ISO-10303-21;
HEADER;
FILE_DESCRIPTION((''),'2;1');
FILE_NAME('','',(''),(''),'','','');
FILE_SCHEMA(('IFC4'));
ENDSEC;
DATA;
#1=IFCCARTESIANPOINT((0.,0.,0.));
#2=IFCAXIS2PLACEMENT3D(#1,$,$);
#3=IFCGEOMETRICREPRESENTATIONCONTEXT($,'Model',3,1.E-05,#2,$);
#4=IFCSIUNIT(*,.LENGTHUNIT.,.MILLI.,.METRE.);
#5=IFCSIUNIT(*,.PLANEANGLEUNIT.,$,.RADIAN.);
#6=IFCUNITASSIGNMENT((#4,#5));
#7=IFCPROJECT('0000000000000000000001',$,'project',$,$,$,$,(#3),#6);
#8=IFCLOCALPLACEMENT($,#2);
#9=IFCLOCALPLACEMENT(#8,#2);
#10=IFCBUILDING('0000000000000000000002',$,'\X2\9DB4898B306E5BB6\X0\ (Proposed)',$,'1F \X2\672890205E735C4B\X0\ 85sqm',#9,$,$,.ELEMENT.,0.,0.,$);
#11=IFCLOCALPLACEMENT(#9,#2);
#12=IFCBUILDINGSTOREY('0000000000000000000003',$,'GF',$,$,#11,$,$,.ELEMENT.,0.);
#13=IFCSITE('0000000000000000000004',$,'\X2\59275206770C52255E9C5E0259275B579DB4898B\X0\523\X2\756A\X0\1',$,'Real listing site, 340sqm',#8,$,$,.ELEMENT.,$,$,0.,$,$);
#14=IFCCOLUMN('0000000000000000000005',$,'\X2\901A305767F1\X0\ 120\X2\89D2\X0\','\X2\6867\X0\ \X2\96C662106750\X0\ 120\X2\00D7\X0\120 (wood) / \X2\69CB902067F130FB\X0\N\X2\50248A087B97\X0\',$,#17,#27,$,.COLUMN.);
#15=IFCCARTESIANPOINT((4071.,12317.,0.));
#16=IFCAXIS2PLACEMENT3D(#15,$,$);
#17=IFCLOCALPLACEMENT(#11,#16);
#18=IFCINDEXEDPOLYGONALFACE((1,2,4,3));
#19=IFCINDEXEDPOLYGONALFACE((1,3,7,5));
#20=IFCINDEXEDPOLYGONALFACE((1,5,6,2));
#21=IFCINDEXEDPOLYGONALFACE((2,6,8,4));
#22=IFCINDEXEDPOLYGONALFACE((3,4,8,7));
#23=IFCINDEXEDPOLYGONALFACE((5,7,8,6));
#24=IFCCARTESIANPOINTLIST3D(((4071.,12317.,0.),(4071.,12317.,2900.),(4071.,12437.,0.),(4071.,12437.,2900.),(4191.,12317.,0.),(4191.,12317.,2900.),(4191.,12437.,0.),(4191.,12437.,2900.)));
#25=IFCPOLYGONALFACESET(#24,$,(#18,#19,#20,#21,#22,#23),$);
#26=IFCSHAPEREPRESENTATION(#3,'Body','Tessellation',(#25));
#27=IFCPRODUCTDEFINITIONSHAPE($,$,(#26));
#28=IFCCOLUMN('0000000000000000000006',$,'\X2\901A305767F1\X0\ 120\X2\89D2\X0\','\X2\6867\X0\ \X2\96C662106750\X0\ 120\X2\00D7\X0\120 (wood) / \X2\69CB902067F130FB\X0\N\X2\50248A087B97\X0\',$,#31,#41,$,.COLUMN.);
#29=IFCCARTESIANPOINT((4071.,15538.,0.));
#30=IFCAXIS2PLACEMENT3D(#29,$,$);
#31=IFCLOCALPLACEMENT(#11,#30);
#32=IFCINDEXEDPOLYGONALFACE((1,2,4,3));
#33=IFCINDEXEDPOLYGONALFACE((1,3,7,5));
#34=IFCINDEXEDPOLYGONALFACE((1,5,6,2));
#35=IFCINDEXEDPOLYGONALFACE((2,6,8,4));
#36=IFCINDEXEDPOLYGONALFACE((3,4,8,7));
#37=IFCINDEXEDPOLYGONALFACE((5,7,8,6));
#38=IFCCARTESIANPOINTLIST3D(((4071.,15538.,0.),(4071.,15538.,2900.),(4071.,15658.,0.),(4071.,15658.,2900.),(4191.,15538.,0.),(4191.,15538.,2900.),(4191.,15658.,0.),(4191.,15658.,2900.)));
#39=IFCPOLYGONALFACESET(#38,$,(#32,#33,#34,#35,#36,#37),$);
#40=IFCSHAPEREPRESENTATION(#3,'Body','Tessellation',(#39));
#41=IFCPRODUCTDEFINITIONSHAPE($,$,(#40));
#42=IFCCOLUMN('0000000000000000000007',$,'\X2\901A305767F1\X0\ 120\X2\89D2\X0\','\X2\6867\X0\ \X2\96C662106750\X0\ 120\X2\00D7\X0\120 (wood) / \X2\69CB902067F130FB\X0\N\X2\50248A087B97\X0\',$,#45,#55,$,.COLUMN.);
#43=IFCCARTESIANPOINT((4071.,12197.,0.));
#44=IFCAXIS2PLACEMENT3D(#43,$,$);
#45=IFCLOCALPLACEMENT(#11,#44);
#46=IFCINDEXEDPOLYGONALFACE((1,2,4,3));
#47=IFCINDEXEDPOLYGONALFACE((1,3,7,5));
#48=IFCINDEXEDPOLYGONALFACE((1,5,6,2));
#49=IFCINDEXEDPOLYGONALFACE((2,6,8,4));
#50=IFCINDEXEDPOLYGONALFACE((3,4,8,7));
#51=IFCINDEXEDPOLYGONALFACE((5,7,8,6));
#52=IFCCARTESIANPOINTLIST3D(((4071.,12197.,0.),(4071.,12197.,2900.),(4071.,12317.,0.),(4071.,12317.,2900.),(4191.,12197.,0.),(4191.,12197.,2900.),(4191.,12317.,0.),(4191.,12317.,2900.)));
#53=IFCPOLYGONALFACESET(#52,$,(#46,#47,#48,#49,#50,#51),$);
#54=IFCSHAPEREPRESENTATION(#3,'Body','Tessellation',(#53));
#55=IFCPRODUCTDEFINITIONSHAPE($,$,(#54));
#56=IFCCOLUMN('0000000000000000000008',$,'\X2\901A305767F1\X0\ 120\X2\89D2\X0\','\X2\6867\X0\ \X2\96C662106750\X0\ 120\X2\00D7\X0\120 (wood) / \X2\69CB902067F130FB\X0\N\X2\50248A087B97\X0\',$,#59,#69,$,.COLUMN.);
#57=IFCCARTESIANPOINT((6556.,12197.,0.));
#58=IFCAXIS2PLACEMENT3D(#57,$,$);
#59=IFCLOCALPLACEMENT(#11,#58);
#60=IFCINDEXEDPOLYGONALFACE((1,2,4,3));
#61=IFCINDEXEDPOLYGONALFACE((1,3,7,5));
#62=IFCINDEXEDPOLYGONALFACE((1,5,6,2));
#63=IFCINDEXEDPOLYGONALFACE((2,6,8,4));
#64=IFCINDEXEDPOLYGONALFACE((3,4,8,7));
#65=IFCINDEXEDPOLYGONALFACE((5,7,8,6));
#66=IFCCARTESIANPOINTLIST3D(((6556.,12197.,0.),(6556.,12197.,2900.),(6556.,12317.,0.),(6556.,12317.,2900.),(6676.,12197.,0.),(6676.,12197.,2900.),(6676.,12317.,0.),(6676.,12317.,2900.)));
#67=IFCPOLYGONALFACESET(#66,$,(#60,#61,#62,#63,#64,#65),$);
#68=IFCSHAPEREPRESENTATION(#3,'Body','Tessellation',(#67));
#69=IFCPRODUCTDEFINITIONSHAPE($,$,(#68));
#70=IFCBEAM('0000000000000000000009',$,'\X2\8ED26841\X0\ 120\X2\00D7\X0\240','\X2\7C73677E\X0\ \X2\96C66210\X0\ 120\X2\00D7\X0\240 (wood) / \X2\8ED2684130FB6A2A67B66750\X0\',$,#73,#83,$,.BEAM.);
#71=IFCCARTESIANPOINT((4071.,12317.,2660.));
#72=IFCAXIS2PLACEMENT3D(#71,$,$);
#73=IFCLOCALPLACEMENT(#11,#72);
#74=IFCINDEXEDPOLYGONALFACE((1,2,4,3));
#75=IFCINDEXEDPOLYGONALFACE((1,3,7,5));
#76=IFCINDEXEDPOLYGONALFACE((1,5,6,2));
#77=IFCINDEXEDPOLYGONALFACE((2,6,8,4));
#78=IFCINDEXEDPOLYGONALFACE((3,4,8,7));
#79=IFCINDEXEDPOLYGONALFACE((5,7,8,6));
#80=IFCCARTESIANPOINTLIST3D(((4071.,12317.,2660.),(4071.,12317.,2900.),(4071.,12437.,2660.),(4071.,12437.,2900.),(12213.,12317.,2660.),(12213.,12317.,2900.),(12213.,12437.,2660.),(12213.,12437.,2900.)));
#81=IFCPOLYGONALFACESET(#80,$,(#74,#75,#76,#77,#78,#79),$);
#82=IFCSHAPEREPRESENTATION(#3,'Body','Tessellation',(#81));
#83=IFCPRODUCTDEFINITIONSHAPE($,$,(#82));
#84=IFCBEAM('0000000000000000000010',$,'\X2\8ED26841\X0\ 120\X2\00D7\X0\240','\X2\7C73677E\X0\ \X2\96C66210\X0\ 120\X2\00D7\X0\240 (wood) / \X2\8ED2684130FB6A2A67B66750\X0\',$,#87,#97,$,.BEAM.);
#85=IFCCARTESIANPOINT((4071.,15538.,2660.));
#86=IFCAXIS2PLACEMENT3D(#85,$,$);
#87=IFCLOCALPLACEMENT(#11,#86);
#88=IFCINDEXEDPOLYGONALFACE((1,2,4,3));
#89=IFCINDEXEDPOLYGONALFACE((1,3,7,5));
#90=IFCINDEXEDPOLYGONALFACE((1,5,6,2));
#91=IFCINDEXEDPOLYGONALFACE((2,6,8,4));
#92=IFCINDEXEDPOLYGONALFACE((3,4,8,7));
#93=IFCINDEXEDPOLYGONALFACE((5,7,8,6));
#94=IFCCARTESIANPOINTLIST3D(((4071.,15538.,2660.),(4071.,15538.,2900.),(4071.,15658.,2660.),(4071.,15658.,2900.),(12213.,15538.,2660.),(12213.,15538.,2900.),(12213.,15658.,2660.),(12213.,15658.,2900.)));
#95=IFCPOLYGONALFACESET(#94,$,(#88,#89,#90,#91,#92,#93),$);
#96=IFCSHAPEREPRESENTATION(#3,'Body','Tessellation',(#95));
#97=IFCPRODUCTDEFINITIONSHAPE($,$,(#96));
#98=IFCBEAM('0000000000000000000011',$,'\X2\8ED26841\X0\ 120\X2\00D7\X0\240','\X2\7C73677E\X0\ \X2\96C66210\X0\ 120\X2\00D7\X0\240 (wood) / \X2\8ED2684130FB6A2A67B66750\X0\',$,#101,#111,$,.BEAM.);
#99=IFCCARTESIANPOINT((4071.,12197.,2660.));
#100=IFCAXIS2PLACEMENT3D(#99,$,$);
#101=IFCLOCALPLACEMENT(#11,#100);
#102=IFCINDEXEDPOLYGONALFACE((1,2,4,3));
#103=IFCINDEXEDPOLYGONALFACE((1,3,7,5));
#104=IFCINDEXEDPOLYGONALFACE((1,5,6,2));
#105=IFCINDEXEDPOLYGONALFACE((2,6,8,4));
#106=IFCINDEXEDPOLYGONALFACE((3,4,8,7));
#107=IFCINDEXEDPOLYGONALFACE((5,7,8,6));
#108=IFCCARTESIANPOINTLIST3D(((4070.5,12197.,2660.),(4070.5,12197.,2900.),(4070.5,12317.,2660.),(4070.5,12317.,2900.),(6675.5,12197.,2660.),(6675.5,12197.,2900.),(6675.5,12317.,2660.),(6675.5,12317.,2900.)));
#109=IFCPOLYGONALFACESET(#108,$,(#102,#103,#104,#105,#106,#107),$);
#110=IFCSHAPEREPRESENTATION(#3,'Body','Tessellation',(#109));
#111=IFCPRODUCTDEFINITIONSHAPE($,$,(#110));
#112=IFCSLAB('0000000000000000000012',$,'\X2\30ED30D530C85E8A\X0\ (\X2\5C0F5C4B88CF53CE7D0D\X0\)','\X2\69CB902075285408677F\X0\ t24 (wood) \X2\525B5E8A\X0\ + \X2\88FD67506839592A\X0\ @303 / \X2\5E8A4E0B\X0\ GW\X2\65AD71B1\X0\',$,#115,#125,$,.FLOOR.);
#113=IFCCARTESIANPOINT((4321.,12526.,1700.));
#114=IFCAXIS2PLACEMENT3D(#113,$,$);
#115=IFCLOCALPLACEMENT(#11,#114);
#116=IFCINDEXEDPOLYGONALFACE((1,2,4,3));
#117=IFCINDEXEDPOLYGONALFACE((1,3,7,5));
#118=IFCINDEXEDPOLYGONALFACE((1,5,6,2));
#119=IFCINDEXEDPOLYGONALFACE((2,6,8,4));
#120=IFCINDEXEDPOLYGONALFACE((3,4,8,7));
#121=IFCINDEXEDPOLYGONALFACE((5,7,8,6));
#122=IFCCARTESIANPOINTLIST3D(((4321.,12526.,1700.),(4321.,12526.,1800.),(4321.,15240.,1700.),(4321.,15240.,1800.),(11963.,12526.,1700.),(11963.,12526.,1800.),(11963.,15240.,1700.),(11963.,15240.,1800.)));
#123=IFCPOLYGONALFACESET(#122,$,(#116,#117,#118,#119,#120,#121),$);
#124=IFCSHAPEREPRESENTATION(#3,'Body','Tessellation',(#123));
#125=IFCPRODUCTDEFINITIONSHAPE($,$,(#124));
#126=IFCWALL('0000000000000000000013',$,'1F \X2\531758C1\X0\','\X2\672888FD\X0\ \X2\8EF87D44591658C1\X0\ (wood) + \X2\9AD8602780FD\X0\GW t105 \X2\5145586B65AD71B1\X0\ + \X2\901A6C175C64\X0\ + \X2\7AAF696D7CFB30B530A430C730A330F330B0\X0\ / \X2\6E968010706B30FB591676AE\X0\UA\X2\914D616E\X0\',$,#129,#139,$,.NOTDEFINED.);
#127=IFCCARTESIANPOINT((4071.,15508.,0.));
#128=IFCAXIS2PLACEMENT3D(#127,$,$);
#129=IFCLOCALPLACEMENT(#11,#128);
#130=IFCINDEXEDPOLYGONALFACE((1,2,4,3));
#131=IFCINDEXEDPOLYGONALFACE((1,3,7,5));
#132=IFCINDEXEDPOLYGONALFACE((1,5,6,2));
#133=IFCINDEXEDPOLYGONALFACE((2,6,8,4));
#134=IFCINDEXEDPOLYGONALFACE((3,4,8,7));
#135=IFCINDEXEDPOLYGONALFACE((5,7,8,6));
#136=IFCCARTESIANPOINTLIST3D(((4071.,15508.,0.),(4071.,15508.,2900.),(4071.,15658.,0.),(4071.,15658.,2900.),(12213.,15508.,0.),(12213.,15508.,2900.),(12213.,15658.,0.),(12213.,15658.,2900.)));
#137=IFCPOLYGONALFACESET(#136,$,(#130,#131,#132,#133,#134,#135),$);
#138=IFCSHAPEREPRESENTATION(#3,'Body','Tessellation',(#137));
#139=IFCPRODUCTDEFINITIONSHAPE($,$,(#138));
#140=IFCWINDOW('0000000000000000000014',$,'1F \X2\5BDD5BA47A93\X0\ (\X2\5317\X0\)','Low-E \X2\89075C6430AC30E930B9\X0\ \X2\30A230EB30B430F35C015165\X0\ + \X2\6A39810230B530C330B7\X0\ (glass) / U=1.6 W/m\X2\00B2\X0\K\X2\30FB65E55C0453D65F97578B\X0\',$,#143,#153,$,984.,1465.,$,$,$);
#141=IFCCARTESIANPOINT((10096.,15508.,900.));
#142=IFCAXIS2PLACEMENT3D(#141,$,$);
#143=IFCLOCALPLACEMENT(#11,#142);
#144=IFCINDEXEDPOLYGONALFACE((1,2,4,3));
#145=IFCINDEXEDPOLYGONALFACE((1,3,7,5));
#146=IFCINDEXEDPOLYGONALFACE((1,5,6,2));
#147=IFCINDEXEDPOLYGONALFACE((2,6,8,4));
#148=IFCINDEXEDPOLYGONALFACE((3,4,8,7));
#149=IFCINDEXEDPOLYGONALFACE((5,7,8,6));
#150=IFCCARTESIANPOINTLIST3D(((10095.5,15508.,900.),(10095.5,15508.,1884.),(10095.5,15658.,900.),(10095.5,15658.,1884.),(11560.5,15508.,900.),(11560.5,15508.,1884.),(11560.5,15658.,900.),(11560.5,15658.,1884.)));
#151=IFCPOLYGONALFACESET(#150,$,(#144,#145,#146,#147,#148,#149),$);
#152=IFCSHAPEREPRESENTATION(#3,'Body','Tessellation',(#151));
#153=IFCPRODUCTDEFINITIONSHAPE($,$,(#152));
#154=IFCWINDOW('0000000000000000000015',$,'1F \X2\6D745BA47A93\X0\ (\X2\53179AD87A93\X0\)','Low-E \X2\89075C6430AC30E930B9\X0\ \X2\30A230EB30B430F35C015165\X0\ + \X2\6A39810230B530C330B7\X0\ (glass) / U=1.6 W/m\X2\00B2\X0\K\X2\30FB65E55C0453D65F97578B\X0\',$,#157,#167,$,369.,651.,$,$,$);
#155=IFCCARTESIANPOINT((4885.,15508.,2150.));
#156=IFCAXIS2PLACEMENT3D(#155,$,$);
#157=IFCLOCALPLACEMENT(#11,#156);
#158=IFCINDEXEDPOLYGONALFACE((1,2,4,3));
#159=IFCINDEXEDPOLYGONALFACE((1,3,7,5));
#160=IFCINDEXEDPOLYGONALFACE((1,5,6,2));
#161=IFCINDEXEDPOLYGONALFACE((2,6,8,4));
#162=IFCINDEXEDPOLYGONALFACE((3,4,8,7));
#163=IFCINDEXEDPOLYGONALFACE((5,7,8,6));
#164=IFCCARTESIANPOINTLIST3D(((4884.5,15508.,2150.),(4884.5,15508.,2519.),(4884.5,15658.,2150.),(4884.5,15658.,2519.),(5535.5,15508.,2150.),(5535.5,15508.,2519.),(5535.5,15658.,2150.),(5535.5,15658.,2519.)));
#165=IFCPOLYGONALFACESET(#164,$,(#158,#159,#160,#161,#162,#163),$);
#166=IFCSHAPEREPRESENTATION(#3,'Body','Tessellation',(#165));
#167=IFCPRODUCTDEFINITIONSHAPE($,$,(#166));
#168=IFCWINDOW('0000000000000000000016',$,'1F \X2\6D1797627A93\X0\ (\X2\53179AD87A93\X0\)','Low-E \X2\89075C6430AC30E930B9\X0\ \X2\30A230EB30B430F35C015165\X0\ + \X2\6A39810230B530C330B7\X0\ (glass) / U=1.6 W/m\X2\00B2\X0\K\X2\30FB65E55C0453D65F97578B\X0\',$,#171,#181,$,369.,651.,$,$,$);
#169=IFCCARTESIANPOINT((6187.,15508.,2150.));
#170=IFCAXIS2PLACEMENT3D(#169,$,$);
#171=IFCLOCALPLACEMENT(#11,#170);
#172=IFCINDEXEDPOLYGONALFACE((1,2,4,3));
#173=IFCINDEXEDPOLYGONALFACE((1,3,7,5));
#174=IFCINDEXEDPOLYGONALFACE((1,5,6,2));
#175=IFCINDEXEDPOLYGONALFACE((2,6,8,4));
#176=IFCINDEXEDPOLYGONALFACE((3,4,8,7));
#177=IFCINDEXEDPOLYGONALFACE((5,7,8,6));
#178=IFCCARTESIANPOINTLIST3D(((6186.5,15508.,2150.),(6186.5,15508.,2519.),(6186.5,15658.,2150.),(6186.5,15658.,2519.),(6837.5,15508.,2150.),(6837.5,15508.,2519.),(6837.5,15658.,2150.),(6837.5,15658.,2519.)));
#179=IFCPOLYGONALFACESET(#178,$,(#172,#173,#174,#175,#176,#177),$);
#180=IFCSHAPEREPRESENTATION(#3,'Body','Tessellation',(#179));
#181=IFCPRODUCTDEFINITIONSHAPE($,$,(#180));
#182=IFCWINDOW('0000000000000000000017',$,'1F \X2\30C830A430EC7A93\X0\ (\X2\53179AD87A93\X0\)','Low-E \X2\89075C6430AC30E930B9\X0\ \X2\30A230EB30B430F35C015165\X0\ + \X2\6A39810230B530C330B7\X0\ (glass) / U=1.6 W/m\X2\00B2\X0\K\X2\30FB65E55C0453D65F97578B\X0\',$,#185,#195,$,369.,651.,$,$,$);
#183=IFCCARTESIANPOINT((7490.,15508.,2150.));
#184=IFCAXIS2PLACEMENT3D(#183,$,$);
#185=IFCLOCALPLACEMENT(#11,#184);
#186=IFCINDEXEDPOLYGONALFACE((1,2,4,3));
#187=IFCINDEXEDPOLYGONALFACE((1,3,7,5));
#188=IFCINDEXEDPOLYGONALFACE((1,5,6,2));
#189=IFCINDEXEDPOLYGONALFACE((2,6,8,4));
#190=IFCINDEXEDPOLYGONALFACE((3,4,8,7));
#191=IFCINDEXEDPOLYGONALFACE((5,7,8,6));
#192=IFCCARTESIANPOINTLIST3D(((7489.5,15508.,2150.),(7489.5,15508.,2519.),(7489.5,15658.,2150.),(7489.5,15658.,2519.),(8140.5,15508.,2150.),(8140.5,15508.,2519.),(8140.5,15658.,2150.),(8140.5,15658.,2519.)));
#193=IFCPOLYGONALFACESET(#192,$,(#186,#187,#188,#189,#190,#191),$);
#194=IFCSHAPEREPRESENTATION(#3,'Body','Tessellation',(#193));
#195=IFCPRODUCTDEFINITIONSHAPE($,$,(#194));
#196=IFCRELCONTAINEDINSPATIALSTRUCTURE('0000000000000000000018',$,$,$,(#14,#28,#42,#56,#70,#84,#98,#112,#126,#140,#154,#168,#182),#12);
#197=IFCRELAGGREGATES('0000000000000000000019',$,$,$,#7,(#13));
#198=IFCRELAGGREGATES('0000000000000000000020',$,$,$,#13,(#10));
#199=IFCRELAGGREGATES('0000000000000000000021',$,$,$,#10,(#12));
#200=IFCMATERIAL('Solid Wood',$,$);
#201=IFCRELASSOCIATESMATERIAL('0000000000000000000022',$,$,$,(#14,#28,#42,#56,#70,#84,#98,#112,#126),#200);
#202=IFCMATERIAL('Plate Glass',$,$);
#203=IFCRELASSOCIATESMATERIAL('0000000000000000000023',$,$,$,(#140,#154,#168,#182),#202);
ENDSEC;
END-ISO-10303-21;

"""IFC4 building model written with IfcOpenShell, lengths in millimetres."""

from ifc_helpers import new_model, si_unit, frame, frame_2d, origin, place, context, project, spatial, rectangle, extrude, material, element, fill, save


model = new_model("IFC4")

# Units and contexts
model_context = context("Model", 3, precision=1e-05, world=origin())
ifc_project = project(units=[si_unit("LENGTHUNIT", "METRE", prefix="MILLI"), si_unit("PLANEANGLEUNIT", "RADIAN")], contexts=[model_context])

# Site, building, storey
site_placement = place(None, origin())
site = spatial("IfcSite", under=ifc_project, at=site_placement, Name="大分県別府市大字鶴見523番1", ObjectType="Real listing site, 340sqm", CompositionType="ELEMENT", RefElevation=0.0)
building_placement = place(site_placement, origin())
building = spatial("IfcBuilding", under=site, at=building_placement, Name="鶴見の家 (Proposed)", ObjectType="1F 木造平屋 85sqm", CompositionType="ELEMENT", ElevationOfRefHeight=0.0, ElevationOfTerrain=0.0)
storey_placement = place(building_placement, origin())
storey = spatial("IfcBuildingStorey", under=building, at=storey_placement, Name="GF", CompositionType="ELEMENT", Elevation=0.0)

# Columns
ifc_material_1 = material(Name="Solid Wood")
column_1_placement = place(storey_placement, frame((4071.0, 12317.0, 0.0)))
element("IfcColumn", 1, at=column_1_placement, inside=storey, material=ifc_material_1, Name="通し柱 120角", Description="桧 集成材 120×120 (wood) / 構造柱・N値計算", PredefinedType="COLUMN", context=model_context, shape_type="SweptSolid", body=[
    extrude(rectangle(XDim=120.0, YDim=120.0, at=frame_2d((60.0, 60.0))), frame((4071.0, 12317.0, 0.0)), (0.0, 0.0, 1.0), 2900.0),
])
column_2_placement = place(storey_placement, frame((4071.0, 15538.0, 0.0)))
element("IfcColumn", 2, at=column_2_placement, inside=storey, material=ifc_material_1, Name="通し柱 120角", Description="桧 集成材 120×120 (wood) / 構造柱・N値計算", PredefinedType="COLUMN", context=model_context, shape_type="SweptSolid", body=[
    extrude(rectangle(XDim=120.0, YDim=120.0, at=frame_2d((60.0, 60.0))), frame((4071.0, 15538.0, 0.0)), (0.0, 0.0, 1.0), 2900.0),
])
column_3_placement = place(storey_placement, frame((4071.0, 12197.0, 0.0)))
element("IfcColumn", 3, at=column_3_placement, inside=storey, material=ifc_material_1, Name="通し柱 120角", Description="桧 集成材 120×120 (wood) / 構造柱・N値計算", PredefinedType="COLUMN", context=model_context, shape_type="SweptSolid", body=[
    extrude(rectangle(XDim=120.0, YDim=120.0, at=frame_2d((60.0, 60.0))), frame((4071.0, 12197.0, 0.0)), (0.0, 0.0, 1.0), 2900.0),
])
column_4_placement = place(storey_placement, frame((6556.0, 12197.0, 0.0)))
element("IfcColumn", 4, at=column_4_placement, inside=storey, material=ifc_material_1, Name="通し柱 120角", Description="桧 集成材 120×120 (wood) / 構造柱・N値計算", PredefinedType="COLUMN", context=model_context, shape_type="SweptSolid", body=[
    extrude(rectangle(XDim=120.0, YDim=120.0, at=frame_2d((60.0, 60.0))), frame((6556.0, 12197.0, 0.0)), (0.0, 0.0, 1.0), 2900.0),
])

# Beams
beam_1_placement = place(storey_placement, frame((4071.0, 12317.0, 2660.0)))
element("IfcBeam", 5, at=beam_1_placement, inside=storey, material=ifc_material_1, Name="軒桁 120×240", Description="米松 集成 120×240 (wood) / 軒桁・横架材", PredefinedType="BEAM", context=model_context, shape_type="SweptSolid", body=[
    extrude(rectangle(XDim=8142.0, YDim=120.0, at=frame_2d((4071.0, 60.0))), frame((4071.0, 12317.0, 2660.0)), (0.0, 0.0, 1.0), 240.0),
])
beam_2_placement = place(storey_placement, frame((4071.0, 15538.0, 2660.0)))
element("IfcBeam", 6, at=beam_2_placement, inside=storey, material=ifc_material_1, Name="軒桁 120×240", Description="米松 集成 120×240 (wood) / 軒桁・横架材", PredefinedType="BEAM", context=model_context, shape_type="SweptSolid", body=[
    extrude(rectangle(XDim=8142.0, YDim=120.0, at=frame_2d((4071.0, 60.0))), frame((4071.0, 15538.0, 2660.0)), (0.0, 0.0, 1.0), 240.0),
])
beam_3_placement = place(storey_placement, frame((4071.0, 12197.0, 2660.0)))
element("IfcBeam", 7, at=beam_3_placement, inside=storey, material=ifc_material_1, Name="軒桁 120×240", Description="米松 集成 120×240 (wood) / 軒桁・横架材", PredefinedType="BEAM", context=model_context, shape_type="SweptSolid", body=[
    extrude(rectangle(XDim=2605.0, YDim=120.0, at=frame_2d((1302.0, 60.0))), frame((4071.0, 12197.0, 2660.0)), (0.0, 0.0, 1.0), 240.0),
])

# Slab
slab_1_placement = place(storey_placement, frame((4321.0, 12526.0, 1700.0)))
element("IfcSlab", 8, at=slab_1_placement, inside=storey, material=ifc_material_1, Name="ロフト床 (小屋裏収納)", Description="構造用合板 t24 (wood) 剛床 + 製材根太 @303 / 床下 GW断熱", PredefinedType="FLOOR", context=model_context, shape_type="SweptSolid", body=[
    extrude(rectangle(XDim=7642.0, YDim=2714.0, at=frame_2d((3821.0, 1357.0))), frame((4321.0, 12526.0, 1700.0)), (0.0, 0.0, 1.0), 100.0),
])

# Wall, openings, windows
wall_1_placement = place(storey_placement, frame((4071.0, 15508.0, 0.0)))
wall_1 = element("IfcWall", 9, at=wall_1_placement, inside=storey, material=ifc_material_1, Name="1F 北壁", Description="木製 軸組外壁 (wood) + 高性能GW t105 充填断熱 + 通気層 + 窯業系サイディング / 準耐火・外皮UA配慮", PredefinedType="NOTDEFINED", context=model_context, shape_type="SweptSolid", body=[
    extrude(rectangle(XDim=8142.0, YDim=150.0, at=frame_2d((4071.0, 75.0))), frame((4071.0, 15508.0, 0.0)), (0.0, 0.0, 1.0), 2900.0),
])
opening_1_placement = place(storey_placement, frame((10096.0, 15508.0, 900.0)))
opening_1 = element("IfcOpeningElement", 10, at=opening_1_placement, cuts=wall_1, PredefinedType="NOTDEFINED", context=model_context, shape_type="SweptSolid", body=[
    extrude(rectangle(XDim=1465.0, YDim=150.0, at=frame_2d((732.0, 75.0))), frame((10096.0, 15508.0, 900.0)), (0.0, 0.0, 1.0), 984.0),
])
opening_2_placement = place(storey_placement, frame((4885.0, 15508.0, 2150.0)))
opening_2 = element("IfcOpeningElement", 11, at=opening_2_placement, cuts=wall_1, PredefinedType="NOTDEFINED", context=model_context, shape_type="SweptSolid", body=[
    extrude(rectangle(XDim=651.0, YDim=150.0, at=frame_2d((325.0, 75.0))), frame((4885.0, 15508.0, 2150.0)), (0.0, 0.0, 1.0), 369.0),
])
opening_3_placement = place(storey_placement, frame((6187.0, 15508.0, 2150.0)))
opening_3 = element("IfcOpeningElement", 12, at=opening_3_placement, cuts=wall_1, PredefinedType="NOTDEFINED", context=model_context, shape_type="SweptSolid", body=[
    extrude(rectangle(XDim=651.0, YDim=150.0, at=frame_2d((325.0, 75.0))), frame((6187.0, 15508.0, 2150.0)), (0.0, 0.0, 1.0), 369.0),
])
opening_4_placement = place(storey_placement, frame((7490.0, 15508.0, 2150.0)))
opening_4 = element("IfcOpeningElement", 13, at=opening_4_placement, cuts=wall_1, PredefinedType="NOTDEFINED", context=model_context, shape_type="SweptSolid", body=[
    extrude(rectangle(XDim=651.0, YDim=150.0, at=frame_2d((325.0, 75.0))), frame((7490.0, 15508.0, 2150.0)), (0.0, 0.0, 1.0), 369.0),
])
ifc_material_2 = material(Name="Plate Glass")
window_1_placement = place(storey_placement, frame((10096.0, 15508.0, 900.0)))
window_1 = element("IfcWindow", 14, at=window_1_placement, inside=storey, material=ifc_material_2, Name="1F 寝室窓 (北)", Description="Low-E 複層ガラス アルゴン封入 + 樹脂サッシ (glass) / U=1.6 W/m²K・日射取得型", OverallHeight=984.0, OverallWidth=1465.0, context=model_context, shape_type="SweptSolid", body=[
    extrude(rectangle(XDim=1465.0, YDim=150.0, at=frame_2d((732.0, 75.0))), frame((10096.0, 15508.0, 900.0)), (0.0, 0.0, 1.0), 984.0),
])
fill(opening_1, window_1)
window_2_placement = place(storey_placement, frame((4885.0, 15508.0, 2150.0)))
window_2 = element("IfcWindow", 15, at=window_2_placement, inside=storey, material=ifc_material_2, Name="1F 浴室窓 (北高窓)", Description="Low-E 複層ガラス アルゴン封入 + 樹脂サッシ (glass) / U=1.6 W/m²K・日射取得型", OverallHeight=369.0, OverallWidth=651.0, context=model_context, shape_type="SweptSolid", body=[
    extrude(rectangle(XDim=651.0, YDim=150.0, at=frame_2d((325.0, 75.0))), frame((4885.0, 15508.0, 2150.0)), (0.0, 0.0, 1.0), 369.0),
])
fill(opening_2, window_2)
window_3_placement = place(storey_placement, frame((6187.0, 15508.0, 2150.0)))
window_3 = element("IfcWindow", 16, at=window_3_placement, inside=storey, material=ifc_material_2, Name="1F 洗面窓 (北高窓)", Description="Low-E 複層ガラス アルゴン封入 + 樹脂サッシ (glass) / U=1.6 W/m²K・日射取得型", OverallHeight=369.0, OverallWidth=651.0, context=model_context, shape_type="SweptSolid", body=[
    extrude(rectangle(XDim=651.0, YDim=150.0, at=frame_2d((325.0, 75.0))), frame((6187.0, 15508.0, 2150.0)), (0.0, 0.0, 1.0), 369.0),
])
fill(opening_3, window_3)
window_4_placement = place(storey_placement, frame((7490.0, 15508.0, 2150.0)))
window_4 = element("IfcWindow", 17, at=window_4_placement, inside=storey, material=ifc_material_2, Name="1F トイレ窓 (北高窓)", Description="Low-E 複層ガラス アルゴン封入 + 樹脂サッシ (glass) / U=1.6 W/m²K・日射取得型", OverallHeight=369.0, OverallWidth=651.0, context=model_context, shape_type="SweptSolid", body=[
    extrude(rectangle(XDim=651.0, YDim=150.0, at=frame_2d((325.0, 75.0))), frame((7490.0, 15508.0, 2150.0)), (0.0, 0.0, 1.0), 369.0),
])
fill(opening_4, window_4)

save(model, "model.ifc")
